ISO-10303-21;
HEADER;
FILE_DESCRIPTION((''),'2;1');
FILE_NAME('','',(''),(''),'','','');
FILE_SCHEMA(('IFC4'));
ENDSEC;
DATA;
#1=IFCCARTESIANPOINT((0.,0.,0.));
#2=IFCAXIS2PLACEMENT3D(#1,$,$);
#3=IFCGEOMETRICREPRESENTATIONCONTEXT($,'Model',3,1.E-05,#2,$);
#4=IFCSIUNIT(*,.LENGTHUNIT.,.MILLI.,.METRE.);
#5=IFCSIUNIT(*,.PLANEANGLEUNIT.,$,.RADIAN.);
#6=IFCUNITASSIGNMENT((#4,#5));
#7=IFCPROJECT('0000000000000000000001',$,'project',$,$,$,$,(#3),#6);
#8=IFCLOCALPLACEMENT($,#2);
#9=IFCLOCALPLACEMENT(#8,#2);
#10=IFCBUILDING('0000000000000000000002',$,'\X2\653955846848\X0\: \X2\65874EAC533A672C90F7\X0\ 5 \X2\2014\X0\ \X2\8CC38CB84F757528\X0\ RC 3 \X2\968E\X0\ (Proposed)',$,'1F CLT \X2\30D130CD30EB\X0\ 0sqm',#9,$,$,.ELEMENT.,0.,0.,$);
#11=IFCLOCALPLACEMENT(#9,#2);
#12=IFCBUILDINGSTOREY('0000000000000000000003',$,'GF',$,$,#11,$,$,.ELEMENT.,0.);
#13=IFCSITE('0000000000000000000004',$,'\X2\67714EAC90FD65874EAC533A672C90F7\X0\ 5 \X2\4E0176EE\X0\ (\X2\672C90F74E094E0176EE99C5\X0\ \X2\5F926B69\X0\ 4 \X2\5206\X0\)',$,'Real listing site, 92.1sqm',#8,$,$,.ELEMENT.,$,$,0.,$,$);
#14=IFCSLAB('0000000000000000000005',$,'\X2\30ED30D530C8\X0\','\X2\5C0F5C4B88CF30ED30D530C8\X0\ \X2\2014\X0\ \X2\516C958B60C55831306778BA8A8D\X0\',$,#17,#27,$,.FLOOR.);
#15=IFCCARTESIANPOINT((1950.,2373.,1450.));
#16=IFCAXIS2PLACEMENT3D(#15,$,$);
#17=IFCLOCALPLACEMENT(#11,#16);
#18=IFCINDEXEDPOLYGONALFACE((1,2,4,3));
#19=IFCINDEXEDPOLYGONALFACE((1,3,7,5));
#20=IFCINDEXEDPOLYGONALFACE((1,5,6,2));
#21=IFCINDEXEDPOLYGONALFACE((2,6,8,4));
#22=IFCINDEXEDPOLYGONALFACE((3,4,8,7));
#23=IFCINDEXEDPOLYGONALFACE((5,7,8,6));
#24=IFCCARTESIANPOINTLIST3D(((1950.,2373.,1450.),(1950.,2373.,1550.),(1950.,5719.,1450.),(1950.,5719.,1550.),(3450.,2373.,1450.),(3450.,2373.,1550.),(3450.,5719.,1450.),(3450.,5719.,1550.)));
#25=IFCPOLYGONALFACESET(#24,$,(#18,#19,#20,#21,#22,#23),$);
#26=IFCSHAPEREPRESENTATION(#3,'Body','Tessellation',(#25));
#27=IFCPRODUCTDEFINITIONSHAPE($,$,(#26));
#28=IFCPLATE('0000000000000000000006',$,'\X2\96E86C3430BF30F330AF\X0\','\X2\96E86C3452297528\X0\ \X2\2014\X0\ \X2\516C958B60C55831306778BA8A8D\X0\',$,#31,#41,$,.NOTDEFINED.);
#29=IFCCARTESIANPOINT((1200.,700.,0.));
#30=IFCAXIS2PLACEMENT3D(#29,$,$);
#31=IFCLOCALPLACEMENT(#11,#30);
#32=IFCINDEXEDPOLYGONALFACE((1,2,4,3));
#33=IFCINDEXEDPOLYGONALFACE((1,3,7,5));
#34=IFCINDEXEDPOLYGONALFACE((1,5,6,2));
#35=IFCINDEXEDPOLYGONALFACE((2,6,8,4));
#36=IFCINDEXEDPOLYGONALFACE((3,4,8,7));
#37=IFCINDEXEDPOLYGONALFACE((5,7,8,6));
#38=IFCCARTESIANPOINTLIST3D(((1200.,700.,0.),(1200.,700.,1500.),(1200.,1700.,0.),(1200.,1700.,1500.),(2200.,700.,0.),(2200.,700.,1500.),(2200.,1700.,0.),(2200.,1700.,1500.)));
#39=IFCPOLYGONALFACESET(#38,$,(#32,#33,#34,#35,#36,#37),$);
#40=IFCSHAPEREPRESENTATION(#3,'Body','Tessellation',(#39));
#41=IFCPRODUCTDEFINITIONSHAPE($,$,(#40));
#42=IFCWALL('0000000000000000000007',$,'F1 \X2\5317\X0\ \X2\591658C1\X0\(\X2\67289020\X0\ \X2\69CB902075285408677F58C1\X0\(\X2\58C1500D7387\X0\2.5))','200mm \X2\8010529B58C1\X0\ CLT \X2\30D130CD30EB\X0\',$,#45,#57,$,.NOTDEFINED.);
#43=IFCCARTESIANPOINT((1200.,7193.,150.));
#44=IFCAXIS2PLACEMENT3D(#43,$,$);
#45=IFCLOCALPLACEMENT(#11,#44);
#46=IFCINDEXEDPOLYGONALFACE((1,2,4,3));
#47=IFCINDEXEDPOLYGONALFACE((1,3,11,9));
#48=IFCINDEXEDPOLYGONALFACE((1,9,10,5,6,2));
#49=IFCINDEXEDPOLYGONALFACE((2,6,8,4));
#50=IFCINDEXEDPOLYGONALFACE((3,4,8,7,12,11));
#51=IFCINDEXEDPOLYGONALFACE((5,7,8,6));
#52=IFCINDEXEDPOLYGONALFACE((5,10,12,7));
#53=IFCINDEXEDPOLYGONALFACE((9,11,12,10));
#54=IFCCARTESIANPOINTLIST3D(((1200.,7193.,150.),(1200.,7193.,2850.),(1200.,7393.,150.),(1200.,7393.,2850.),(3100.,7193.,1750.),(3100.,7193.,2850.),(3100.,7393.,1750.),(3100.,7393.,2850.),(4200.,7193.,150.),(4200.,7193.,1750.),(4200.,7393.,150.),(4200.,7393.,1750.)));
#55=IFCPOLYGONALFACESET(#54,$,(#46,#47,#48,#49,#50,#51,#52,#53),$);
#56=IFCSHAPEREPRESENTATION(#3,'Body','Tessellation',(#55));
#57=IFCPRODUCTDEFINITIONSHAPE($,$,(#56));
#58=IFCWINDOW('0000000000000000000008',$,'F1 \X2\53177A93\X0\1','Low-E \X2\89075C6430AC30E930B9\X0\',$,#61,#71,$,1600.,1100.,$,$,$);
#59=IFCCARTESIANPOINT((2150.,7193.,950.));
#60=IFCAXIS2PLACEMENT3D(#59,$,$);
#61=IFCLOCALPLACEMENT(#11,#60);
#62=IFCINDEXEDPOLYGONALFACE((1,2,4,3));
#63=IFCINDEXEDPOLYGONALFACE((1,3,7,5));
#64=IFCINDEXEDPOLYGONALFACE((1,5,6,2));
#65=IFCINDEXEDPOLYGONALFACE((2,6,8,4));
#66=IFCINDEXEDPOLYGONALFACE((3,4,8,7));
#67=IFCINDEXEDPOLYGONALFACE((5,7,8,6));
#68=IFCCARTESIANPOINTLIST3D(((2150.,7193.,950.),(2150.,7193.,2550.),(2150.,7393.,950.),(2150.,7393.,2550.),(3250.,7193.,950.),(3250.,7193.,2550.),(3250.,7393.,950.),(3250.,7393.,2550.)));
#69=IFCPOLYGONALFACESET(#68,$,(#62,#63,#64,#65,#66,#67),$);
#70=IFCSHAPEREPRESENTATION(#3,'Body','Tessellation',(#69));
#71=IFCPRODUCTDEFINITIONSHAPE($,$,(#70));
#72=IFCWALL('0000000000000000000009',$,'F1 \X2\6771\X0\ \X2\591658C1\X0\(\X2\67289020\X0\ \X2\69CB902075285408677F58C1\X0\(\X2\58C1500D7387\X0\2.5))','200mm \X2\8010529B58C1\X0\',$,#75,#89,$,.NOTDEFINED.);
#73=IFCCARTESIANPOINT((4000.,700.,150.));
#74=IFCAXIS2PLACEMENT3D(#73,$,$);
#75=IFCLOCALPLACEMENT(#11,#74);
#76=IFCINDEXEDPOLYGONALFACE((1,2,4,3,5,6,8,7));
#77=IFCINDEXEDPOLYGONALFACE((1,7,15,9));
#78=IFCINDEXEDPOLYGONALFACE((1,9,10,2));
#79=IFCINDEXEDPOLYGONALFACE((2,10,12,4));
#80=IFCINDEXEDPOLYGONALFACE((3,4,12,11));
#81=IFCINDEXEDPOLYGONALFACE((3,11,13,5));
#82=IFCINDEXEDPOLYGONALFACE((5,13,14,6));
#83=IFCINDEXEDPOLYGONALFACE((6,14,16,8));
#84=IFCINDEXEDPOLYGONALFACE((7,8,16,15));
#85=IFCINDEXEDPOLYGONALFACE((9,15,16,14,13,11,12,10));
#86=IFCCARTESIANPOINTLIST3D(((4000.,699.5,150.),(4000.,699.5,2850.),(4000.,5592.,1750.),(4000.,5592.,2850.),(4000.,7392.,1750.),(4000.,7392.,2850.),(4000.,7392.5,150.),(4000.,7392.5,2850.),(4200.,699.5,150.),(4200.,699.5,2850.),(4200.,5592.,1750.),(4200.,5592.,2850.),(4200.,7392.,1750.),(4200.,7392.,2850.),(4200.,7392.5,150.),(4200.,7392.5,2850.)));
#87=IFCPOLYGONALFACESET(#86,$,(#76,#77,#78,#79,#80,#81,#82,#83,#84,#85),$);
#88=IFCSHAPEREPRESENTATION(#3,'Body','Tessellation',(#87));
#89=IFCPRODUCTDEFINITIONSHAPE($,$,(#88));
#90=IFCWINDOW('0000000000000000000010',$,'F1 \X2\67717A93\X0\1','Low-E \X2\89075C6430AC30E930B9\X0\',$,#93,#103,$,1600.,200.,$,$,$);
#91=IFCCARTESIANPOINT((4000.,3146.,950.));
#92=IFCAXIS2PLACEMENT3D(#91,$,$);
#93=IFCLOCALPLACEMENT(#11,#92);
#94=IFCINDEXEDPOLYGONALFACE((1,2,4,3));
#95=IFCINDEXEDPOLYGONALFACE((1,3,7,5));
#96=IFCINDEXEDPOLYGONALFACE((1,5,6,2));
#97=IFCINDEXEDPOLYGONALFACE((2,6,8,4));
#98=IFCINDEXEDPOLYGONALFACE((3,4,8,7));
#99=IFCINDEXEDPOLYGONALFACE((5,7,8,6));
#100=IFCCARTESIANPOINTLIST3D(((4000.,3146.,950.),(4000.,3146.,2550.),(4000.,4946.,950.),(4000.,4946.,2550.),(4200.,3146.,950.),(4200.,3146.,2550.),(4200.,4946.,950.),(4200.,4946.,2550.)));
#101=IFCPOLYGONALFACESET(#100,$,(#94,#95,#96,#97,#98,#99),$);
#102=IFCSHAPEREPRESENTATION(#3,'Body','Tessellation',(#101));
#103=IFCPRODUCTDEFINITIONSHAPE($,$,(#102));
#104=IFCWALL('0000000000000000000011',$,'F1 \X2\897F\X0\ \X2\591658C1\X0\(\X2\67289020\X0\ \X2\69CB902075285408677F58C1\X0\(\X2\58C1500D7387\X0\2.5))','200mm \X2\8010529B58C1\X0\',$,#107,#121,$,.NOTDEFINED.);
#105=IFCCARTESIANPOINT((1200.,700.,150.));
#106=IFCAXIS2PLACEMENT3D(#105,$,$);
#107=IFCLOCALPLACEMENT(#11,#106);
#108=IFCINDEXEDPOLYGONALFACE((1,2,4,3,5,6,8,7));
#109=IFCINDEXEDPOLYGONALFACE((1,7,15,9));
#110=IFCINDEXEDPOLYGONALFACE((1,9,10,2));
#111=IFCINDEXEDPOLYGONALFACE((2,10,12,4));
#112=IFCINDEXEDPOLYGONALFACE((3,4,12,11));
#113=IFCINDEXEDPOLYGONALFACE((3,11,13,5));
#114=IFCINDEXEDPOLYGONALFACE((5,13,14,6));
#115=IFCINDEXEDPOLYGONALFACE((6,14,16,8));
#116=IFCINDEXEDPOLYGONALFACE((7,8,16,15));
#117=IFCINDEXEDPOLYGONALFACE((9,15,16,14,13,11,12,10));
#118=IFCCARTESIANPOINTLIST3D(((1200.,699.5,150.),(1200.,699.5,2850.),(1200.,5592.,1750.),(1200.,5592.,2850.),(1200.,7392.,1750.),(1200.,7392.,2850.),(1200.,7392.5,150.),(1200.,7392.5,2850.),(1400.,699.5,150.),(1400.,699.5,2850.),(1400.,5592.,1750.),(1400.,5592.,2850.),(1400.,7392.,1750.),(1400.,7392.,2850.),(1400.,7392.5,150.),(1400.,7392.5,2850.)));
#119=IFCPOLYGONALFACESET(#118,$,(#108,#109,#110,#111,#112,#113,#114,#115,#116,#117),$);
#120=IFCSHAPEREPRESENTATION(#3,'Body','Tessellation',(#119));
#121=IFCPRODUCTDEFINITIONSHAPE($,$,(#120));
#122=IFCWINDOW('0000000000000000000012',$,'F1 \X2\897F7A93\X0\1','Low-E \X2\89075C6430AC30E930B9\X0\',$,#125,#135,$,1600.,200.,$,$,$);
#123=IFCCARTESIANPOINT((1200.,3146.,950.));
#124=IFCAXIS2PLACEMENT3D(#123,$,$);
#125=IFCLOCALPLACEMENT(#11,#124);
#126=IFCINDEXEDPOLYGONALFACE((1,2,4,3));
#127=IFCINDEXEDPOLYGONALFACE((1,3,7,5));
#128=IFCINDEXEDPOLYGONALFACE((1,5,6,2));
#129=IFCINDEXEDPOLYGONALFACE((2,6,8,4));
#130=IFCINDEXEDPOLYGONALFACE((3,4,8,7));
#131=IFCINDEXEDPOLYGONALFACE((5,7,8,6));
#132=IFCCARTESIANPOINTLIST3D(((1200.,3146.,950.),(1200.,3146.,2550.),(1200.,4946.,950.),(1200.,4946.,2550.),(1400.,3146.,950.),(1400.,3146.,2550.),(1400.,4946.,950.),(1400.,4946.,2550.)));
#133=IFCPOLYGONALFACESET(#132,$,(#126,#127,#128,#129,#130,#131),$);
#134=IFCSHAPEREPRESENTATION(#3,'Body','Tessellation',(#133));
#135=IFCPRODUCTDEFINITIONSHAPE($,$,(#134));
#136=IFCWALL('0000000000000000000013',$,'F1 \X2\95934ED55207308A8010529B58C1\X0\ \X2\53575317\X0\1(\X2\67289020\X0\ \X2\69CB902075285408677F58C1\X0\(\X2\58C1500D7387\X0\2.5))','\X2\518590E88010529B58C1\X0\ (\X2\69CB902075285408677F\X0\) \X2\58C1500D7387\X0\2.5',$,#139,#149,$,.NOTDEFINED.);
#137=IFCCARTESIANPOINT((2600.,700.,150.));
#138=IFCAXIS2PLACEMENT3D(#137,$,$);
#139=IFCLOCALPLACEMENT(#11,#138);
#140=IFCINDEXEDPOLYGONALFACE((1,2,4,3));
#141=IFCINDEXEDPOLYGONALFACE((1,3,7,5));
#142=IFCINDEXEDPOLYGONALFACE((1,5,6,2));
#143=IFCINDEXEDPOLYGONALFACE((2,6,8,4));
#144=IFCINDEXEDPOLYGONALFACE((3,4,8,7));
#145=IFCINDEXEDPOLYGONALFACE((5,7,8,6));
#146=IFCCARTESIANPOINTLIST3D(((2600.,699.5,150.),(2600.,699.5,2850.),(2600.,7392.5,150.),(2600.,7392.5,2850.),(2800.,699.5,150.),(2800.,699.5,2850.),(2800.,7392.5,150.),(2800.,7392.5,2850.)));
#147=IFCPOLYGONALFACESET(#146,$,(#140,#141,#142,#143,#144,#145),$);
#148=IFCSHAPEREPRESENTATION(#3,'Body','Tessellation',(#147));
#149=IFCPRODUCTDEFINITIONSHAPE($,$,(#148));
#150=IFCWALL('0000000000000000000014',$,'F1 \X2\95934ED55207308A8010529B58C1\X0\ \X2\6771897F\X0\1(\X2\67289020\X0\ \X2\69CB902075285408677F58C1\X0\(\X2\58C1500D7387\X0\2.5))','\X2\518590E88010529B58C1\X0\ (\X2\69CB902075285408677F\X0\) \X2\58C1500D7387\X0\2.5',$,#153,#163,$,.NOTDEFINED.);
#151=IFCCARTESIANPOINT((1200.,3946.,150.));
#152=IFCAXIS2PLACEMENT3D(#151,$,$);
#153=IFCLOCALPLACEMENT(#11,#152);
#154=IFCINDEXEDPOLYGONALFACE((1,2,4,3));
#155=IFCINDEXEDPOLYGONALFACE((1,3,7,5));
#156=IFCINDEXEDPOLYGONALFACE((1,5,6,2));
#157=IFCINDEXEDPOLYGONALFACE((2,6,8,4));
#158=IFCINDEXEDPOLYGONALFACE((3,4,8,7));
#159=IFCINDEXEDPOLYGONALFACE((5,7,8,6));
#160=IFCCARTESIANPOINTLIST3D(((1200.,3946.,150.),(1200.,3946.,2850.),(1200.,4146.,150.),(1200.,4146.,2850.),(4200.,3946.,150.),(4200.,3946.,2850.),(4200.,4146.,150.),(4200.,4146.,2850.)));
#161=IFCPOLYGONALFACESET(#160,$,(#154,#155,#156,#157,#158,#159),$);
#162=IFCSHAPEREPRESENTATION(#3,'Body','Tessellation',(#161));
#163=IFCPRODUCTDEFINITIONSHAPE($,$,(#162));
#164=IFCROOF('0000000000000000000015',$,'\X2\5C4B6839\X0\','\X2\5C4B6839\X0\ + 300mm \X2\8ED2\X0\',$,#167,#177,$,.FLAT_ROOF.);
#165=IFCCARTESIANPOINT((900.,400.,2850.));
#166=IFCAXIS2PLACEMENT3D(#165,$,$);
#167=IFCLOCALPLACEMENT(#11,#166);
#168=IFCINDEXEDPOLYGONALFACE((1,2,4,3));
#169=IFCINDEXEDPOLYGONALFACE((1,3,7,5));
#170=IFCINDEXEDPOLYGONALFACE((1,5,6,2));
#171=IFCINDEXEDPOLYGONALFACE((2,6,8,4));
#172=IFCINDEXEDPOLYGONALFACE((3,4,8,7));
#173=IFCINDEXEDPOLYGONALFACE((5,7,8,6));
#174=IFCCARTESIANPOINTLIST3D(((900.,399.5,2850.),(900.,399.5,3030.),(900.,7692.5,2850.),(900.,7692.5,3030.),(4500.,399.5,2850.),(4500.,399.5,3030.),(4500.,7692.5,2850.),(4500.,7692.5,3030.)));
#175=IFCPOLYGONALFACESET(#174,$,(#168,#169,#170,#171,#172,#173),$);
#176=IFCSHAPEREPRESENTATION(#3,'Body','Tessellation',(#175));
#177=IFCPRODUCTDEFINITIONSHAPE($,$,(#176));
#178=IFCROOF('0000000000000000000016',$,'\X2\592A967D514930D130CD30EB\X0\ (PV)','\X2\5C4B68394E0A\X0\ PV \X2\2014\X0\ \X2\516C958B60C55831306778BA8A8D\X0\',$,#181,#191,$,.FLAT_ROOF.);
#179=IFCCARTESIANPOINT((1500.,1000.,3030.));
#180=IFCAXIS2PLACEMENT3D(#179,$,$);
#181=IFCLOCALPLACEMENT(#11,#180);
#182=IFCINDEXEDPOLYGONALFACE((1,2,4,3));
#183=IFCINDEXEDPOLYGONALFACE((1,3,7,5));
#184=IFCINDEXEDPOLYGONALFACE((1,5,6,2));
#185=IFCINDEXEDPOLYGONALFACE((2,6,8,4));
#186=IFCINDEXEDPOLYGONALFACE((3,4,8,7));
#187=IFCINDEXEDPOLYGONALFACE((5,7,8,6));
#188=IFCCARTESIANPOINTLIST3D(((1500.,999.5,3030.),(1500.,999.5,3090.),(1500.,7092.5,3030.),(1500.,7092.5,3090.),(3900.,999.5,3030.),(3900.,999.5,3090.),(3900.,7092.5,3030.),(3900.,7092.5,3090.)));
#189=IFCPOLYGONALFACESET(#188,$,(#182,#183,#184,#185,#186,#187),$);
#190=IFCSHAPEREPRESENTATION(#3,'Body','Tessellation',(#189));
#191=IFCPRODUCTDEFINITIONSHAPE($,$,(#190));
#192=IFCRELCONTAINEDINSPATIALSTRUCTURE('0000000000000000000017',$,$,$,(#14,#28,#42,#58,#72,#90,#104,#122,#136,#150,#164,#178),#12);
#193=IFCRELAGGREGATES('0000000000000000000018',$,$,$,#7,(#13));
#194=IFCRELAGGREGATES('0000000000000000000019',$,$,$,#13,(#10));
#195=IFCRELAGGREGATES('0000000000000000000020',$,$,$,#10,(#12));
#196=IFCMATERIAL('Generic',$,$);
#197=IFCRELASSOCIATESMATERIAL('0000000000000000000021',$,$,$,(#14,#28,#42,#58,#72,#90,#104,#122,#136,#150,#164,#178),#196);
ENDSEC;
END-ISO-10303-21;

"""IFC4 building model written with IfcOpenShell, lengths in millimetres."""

from ifc_helpers import new_model, si_unit, frame, frame_2d, origin, place, context, project, spatial, rectangle, extrude, material, element, fill, save


model = new_model("IFC4")

# Units and contexts
model_context = context("Model", 3, precision=1e-05, world=origin())
ifc_project = project(units=[si_unit("LENGTHUNIT", "METRE", prefix="MILLI"), si_unit("PLANEANGLEUNIT", "RADIAN")], contexts=[model_context])

# Site, building, storey
site_placement = place(None, origin())
site = spatial("IfcSite", under=ifc_project, at=site_placement, Name="東京都文京区本郷 5 丁目 (本郷三丁目駅 徒歩 4 分)", ObjectType="Real listing site, 92.1sqm", CompositionType="ELEMENT", RefElevation=0.0)
building_placement = place(site_placement, origin())
building = spatial("IfcBuilding", under=site, at=building_placement, Name="改善案: 文京区本郷 5 — 賃貸併用 RC 3 階 (Proposed)", ObjectType="1F CLT パネル 0sqm", CompositionType="ELEMENT", ElevationOfRefHeight=0.0, ElevationOfTerrain=0.0)
storey_placement = place(building_placement, origin())
storey = spatial("IfcBuildingStorey", under=building, at=storey_placement, Name="GF", CompositionType="ELEMENT", Elevation=0.0)

# Slab
ifc_material_1 = material(Name="Generic")
slab_1_placement = place(storey_placement, frame((1950.0, 2373.0, 1450.0)))
element("IfcSlab", 1, at=slab_1_placement, inside=storey, material=ifc_material_1, Name="ロフト", Description="小屋裏ロフト — 公開情報で確認", PredefinedType="FLOOR", context=model_context, shape_type="SweptSolid", body=[
    extrude(rectangle(XDim=1500.0, YDim=3346.0, at=frame_2d((750.0, 1673.0))), frame((1950.0, 2373.0, 1450.0)), (0.0, 0.0, 1.0), 100.0),
])

# Plate
plate_placement = place(storey_placement, frame((1200.0, 700.0, 0.0)))
element("IfcPlate", 2, at=plate_placement, inside=storey, material=ifc_material_1, Name="雨水タンク", Description="雨水利用 — 公開情報で確認", PredefinedType="NOTDEFINED", context=model_context, shape_type="SweptSolid", body=[
    extrude(rectangle(XDim=1000.0, YDim=1000.0, at=frame_2d((500.0, 500.0))), frame((1200.0, 700.0, 0.0)), (0.0, 0.0, 1.0), 1500.0),
])

# Wall, opening, window
wall_1_placement = place(storey_placement, frame((1200.0, 7193.0, 150.0)))
wall_1 = element("IfcWall", 3, at=wall_1_placement, inside=storey, material=ifc_material_1, Name="F1 北 外壁(木造 構造用合板壁(壁倍率2.5))", Description="200mm 耐力壁 CLT パネル", PredefinedType="NOTDEFINED", context=model_context, shape_type="SweptSolid", body=[
    extrude(rectangle(XDim=3000.0, YDim=200.0, at=frame_2d((1500.0, 100.0))), frame((1200.0, 7193.0, 150.0)), (0.0, 0.0, 1.0), 2700.0),
])
opening_1_placement = place(storey_placement, frame((2150.0, 7193.0, 950.0)))
opening_1 = element("IfcOpeningElement", 4, at=opening_1_placement, cuts=wall_1, PredefinedType="NOTDEFINED", context=model_context, shape_type="SweptSolid", body=[
    extrude(rectangle(XDim=1100.0, YDim=200.0, at=frame_2d((550.0, 100.0))), frame((2150.0, 7193.0, 950.0)), (0.0, 0.0, 1.0), 1600.0),
])
window_1_placement = place(storey_placement, frame((2150.0, 7193.0, 950.0)))
window_1 = element("IfcWindow", 5, at=window_1_placement, inside=storey, material=ifc_material_1, Name="F1 北窓1", Description="Low-E 複層ガラス", OverallHeight=1600.0, OverallWidth=1100.0, context=model_context, shape_type="SweptSolid", body=[
    extrude(rectangle(XDim=1100.0, YDim=200.0, at=frame_2d((550.0, 100.0))), frame((2150.0, 7193.0, 950.0)), (0.0, 0.0, 1.0), 1600.0),
])
fill(opening_1, window_1)

# Walls, openings, windows
wall_2_placement = place(storey_placement, frame((4000.0, 700.0, 150.0)))
wall_2 = element("IfcWall", 6, at=wall_2_placement, inside=storey, material=ifc_material_1, Name="F1 東 外壁(木造 構造用合板壁(壁倍率2.5))", Description="200mm 耐力壁", PredefinedType="NOTDEFINED", context=model_context, shape_type="SweptSolid", body=[
    extrude(rectangle(XDim=200.0, YDim=6693.0, at=frame_2d((100.0, 3346.0))), frame((4000.0, 700.0, 150.0)), (0.0, 0.0, 1.0), 2700.0),
])
opening_2_placement = place(storey_placement, frame((4000.0, 3146.0, 950.0)))
opening_2 = element("IfcOpeningElement", 7, at=opening_2_placement, cuts=wall_2, PredefinedType="NOTDEFINED", context=model_context, shape_type="SweptSolid", body=[
    extrude(rectangle(XDim=200.0, YDim=1800.0, at=frame_2d((100.0, 900.0))), frame((4000.0, 3146.0, 950.0)), (0.0, 0.0, 1.0), 1600.0),
])
window_2_placement = place(storey_placement, frame((4000.0, 3146.0, 950.0)))
window_2 = element("IfcWindow", 8, at=window_2_placement, inside=storey, material=ifc_material_1, Name="F1 東窓1", Description="Low-E 複層ガラス", OverallHeight=1600.0, OverallWidth=200.0, context=model_context, shape_type="SweptSolid", body=[
    extrude(rectangle(XDim=200.0, YDim=1800.0, at=frame_2d((100.0, 900.0))), frame((4000.0, 3146.0, 950.0)), (0.0, 0.0, 1.0), 1600.0),
])
fill(opening_2, window_2)
wall_3_placement = place(storey_placement, frame((1200.0, 700.0, 150.0)))
wall_3 = element("IfcWall", 9, at=wall_3_placement, inside=storey, material=ifc_material_1, Name="F1 西 外壁(木造 構造用合板壁(壁倍率2.5))", Description="200mm 耐力壁", PredefinedType="NOTDEFINED", context=model_context, shape_type="SweptSolid", body=[
    extrude(rectangle(XDim=200.0, YDim=6693.0, at=frame_2d((100.0, 3346.0))), frame((1200.0, 700.0, 150.0)), (0.0, 0.0, 1.0), 2700.0),
])
opening_3_placement = place(storey_placement, frame((1200.0, 3146.0, 950.0)))
opening_3 = element("IfcOpeningElement", 10, at=opening_3_placement, cuts=wall_3, PredefinedType="NOTDEFINED", context=model_context, shape_type="SweptSolid", body=[
    extrude(rectangle(XDim=200.0, YDim=1800.0, at=frame_2d((100.0, 900.0))), frame((1200.0, 3146.0, 950.0)), (0.0, 0.0, 1.0), 1600.0),
])
window_3_placement = place(storey_placement, frame((1200.0, 3146.0, 950.0)))
window_3 = element("IfcWindow", 11, at=window_3_placement, inside=storey, material=ifc_material_1, Name="F1 西窓1", Description="Low-E 複層ガラス", OverallHeight=1600.0, OverallWidth=200.0, context=model_context, shape_type="SweptSolid", body=[
    extrude(rectangle(XDim=200.0, YDim=1800.0, at=frame_2d((100.0, 900.0))), frame((1200.0, 3146.0, 950.0)), (0.0, 0.0, 1.0), 1600.0),
])
fill(opening_3, window_3)

# Walls
wall_4_placement = place(storey_placement, frame((2600.0, 700.0, 150.0)))
element("IfcWall", 12, at=wall_4_placement, inside=storey, material=ifc_material_1, Name="F1 間仕切り耐力壁 南北1(木造 構造用合板壁(壁倍率2.5))", Description="内部耐力壁 (構造用合板) 壁倍率2.5", PredefinedType="NOTDEFINED", context=model_context, shape_type="SweptSolid", body=[
    extrude(rectangle(XDim=200.0, YDim=6693.0, at=frame_2d((100.0, 3346.0))), frame((2600.0, 700.0, 150.0)), (0.0, 0.0, 1.0), 2700.0),
])
wall_5_placement = place(storey_placement, frame((1200.0, 3946.0, 150.0)))
element("IfcWall", 13, at=wall_5_placement, inside=storey, material=ifc_material_1, Name="F1 間仕切り耐力壁 東西1(木造 構造用合板壁(壁倍率2.5))", Description="内部耐力壁 (構造用合板) 壁倍率2.5", PredefinedType="NOTDEFINED", context=model_context, shape_type="SweptSolid", body=[
    extrude(rectangle(XDim=3000.0, YDim=200.0, at=frame_2d((1500.0, 100.0))), frame((1200.0, 3946.0, 150.0)), (0.0, 0.0, 1.0), 2700.0),
])

# Roofs
roof_1_placement = place(storey_placement, frame((900.0, 400.0, 2850.0)))
element("IfcRoof", 14, at=roof_1_placement, inside=storey, material=ifc_material_1, Name="屋根", Description="屋根 + 300mm 軒", PredefinedType="FLAT_ROOF", context=model_context, shape_type="SweptSolid", body=[
    extrude(rectangle(XDim=3600.0, YDim=7293.0, at=frame_2d((1800.0, 3646.0))), frame((900.0, 400.0, 2850.0)), (0.0, 0.0, 1.0), 180.0),
])
roof_2_placement = place(storey_placement, frame((1500.0, 1000.0, 3030.0)))
element("IfcRoof", 15, at=roof_2_placement, inside=storey, material=ifc_material_1, Name="太陽光パネル (PV)", Description="屋根上 PV — 公開情報で確認", PredefinedType="FLAT_ROOF", context=model_context, shape_type="SweptSolid", body=[
    extrude(rectangle(XDim=2400.0, YDim=6093.0, at=frame_2d((1200.0, 3046.0))), frame((1500.0, 1000.0, 3030.0)), (0.0, 0.0, 1.0), 60.0),
])

save(model, "model.ifc")
